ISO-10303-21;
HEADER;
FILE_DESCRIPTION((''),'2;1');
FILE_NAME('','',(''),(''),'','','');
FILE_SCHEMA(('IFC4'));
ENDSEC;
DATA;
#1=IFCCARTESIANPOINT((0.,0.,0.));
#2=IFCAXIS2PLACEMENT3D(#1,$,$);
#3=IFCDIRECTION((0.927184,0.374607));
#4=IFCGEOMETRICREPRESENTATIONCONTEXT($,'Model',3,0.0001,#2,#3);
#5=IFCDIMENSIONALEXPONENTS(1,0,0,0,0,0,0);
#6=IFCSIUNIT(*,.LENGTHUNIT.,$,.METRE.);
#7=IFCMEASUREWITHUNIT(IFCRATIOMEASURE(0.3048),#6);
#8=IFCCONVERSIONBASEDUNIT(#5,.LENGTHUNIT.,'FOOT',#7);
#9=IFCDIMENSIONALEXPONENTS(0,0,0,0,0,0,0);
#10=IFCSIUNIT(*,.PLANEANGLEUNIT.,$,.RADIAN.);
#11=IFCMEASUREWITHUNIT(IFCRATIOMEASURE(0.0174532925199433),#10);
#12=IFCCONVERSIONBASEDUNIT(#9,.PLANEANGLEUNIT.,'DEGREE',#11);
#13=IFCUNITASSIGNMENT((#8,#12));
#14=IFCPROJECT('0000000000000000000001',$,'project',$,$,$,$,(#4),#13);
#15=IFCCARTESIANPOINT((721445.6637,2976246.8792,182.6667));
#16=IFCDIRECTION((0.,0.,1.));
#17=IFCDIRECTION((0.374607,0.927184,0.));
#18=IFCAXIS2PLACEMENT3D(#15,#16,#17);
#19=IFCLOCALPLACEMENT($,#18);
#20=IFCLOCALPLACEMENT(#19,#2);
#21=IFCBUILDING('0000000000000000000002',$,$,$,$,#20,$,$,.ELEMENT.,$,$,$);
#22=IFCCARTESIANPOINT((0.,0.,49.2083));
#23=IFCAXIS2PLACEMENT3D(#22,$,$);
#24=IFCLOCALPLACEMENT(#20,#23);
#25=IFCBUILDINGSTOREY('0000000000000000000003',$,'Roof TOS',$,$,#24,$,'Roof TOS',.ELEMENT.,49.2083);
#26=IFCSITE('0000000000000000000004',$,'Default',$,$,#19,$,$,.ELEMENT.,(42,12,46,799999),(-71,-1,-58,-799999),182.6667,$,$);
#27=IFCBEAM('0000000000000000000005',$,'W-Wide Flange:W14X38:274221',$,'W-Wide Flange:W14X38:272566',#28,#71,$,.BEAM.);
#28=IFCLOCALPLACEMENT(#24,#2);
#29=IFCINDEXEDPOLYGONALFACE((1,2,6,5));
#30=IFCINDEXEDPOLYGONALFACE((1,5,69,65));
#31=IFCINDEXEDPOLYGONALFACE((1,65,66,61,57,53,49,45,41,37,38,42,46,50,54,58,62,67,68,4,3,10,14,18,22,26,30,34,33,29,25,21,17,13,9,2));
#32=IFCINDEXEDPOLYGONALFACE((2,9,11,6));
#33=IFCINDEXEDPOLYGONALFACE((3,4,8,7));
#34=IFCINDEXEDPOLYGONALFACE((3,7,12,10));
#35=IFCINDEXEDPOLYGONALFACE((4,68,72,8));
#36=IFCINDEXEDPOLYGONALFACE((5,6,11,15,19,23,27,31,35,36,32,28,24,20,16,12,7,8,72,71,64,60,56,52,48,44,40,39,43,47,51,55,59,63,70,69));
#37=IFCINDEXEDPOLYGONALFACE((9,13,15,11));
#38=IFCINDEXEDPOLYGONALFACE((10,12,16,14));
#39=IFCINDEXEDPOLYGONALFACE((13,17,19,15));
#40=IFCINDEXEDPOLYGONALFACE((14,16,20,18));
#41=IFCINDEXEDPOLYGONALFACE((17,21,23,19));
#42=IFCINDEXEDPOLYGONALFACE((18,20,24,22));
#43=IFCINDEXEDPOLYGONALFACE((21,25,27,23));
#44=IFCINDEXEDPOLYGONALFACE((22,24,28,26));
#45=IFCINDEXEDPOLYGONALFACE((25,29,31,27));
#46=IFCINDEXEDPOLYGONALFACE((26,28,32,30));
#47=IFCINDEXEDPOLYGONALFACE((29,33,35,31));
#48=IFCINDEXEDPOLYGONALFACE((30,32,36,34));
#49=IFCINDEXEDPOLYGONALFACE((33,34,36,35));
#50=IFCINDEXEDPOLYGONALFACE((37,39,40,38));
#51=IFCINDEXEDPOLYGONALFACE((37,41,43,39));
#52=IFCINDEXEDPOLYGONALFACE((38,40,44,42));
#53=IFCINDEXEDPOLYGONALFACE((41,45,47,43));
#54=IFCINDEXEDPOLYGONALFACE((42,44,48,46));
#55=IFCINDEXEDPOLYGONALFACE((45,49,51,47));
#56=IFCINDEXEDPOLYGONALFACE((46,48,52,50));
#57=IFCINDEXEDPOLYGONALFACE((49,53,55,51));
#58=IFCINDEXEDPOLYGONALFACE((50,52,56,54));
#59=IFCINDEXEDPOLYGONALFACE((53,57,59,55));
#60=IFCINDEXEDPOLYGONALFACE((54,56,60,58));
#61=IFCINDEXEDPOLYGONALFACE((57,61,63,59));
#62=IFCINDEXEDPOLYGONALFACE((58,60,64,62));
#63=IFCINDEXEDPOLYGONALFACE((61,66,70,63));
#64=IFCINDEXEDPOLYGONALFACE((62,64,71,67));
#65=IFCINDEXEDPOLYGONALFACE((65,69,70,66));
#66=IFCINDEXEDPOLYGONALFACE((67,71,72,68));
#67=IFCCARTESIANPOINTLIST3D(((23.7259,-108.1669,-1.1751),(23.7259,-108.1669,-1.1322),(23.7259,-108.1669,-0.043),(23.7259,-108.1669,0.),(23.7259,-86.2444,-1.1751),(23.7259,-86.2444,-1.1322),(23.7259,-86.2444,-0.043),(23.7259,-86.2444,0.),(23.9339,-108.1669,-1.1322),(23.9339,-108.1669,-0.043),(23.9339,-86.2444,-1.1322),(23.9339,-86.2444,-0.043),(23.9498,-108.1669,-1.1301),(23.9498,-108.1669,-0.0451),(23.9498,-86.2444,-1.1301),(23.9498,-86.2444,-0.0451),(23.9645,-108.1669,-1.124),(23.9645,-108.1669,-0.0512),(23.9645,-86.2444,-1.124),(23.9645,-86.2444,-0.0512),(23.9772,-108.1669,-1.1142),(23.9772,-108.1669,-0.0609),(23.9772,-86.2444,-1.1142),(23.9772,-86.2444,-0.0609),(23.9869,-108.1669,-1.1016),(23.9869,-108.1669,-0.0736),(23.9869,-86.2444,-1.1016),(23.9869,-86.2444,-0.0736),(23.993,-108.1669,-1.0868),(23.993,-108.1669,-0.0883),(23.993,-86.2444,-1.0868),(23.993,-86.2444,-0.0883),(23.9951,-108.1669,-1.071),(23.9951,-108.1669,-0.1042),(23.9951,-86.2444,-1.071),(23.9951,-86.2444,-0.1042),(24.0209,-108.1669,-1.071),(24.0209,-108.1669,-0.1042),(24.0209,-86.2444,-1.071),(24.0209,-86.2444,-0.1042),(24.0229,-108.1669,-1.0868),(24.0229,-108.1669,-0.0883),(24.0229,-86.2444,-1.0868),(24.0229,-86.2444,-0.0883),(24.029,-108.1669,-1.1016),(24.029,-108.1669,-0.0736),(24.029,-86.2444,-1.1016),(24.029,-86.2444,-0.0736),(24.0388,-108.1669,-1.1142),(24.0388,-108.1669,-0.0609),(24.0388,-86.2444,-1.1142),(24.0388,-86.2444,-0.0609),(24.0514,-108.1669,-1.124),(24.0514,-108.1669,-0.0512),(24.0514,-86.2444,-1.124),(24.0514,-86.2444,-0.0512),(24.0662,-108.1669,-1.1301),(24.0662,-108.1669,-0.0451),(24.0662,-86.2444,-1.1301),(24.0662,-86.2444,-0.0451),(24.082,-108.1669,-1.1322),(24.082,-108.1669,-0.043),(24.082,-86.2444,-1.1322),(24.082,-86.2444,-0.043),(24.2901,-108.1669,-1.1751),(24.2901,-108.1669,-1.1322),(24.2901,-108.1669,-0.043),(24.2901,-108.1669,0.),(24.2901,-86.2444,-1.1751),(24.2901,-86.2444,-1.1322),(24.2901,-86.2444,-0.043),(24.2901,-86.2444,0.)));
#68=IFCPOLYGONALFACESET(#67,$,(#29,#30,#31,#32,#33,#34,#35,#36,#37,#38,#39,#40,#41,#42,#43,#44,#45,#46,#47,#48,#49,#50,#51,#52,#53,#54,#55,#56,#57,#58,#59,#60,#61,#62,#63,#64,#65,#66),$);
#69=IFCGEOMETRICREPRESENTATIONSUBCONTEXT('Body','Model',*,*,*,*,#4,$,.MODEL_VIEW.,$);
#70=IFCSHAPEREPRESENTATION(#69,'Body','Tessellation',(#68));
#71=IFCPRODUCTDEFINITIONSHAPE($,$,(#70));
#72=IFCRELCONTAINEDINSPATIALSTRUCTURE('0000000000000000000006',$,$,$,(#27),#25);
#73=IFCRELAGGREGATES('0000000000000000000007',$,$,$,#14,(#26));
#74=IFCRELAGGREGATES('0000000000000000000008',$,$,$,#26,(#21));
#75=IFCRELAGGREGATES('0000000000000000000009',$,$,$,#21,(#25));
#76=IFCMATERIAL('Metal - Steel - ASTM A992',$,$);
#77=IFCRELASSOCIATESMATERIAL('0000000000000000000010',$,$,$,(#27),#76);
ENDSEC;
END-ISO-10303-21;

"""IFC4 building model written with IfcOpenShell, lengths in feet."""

from ifc_helpers import new_model, entity, si_unit, converted_unit, direction, frame, frame_2d, origin, place, context, subcontext, project, spatial, i_section, extrude, material, element, save


model = new_model("IFC4")

# Units and contexts
model_context = context("Model", 3, precision=0.0001, world=origin(), true_north=direction((0.927184, 0.374607)))
body_context = subcontext(model_context, "Body", "Model", "MODEL_VIEW")
ifc_project = project(units=[converted_unit("LENGTHUNIT", "FOOT", entity("IfcRatioMeasure", 0.3048), si_unit("LENGTHUNIT", "METRE"), dimensions=[1, 0, 0, 0, 0, 0, 0]), converted_unit("PLANEANGLEUNIT", "DEGREE", entity("IfcRatioMeasure", 0.0174532925199433), si_unit("PLANEANGLEUNIT", "RADIAN"), dimensions=[0, 0, 0, 0, 0, 0, 0])], contexts=[model_context])

# Site, building, storey
site_placement = place(None, frame((721445.6637, 2976246.8792, 182.6667), z_axis=(0.0, 0.0, 1.0), x_axis=(0.374607, 0.927184, 0.0)))
site = spatial("IfcSite", under=ifc_project, at=site_placement, Name="Default", CompositionType="ELEMENT", RefLatitude=(42, 12, 46, 799999), RefLongitude=(-71, -1, -58, -799999), RefElevation=182.6667)
building_placement = place(site_placement, origin())
building = spatial("IfcBuilding", under=site, at=building_placement, CompositionType="ELEMENT")
storey_placement = place(building_placement, frame((0.0, 0.0, 49.2083)))
storey = spatial("IfcBuildingStorey", under=building, at=storey_placement, Name="Roof TOS", LongName="Roof TOS", CompositionType="ELEMENT", Elevation=49.2083)

# Beam
ifc_material = material(Name="Metal - Steel - ASTM A992")
for number, where, z_axis, x_axis, name in (
    (1, (24.008, -85.8544, 0.0), (0.0, 0.0, 1.0), (0.0, -1.0, 0.0), "W-Wide Flange:W14X38:274221"),
):
    element("IfcBeam", number, at=place(storey_placement, frame(where, z_axis=z_axis, x_axis=x_axis)), inside=storey, material=ifc_material, Name=name, ObjectType="W-Wide Flange:W14X38:272566", PredefinedType="BEAM", context=body_context, shape_type="SweptSolid", body=[
        extrude(i_section(OverallWidth=0.5641, OverallDepth=1.1751, WebThickness=0.0257, FlangeThickness=0.043, FilletRadius=0.0612, at=frame_2d((0.0, 0.0), x_axis=(0.0, 1.0))), frame((0.39, 0.0, -0.5876), z_axis=(1.0, 0.0, 0.0), x_axis=(0.0, 0.0, -1.0)), (0.0, 0.0, 1.0), 21.9225),
    ])

save(model, "model.ifc")
